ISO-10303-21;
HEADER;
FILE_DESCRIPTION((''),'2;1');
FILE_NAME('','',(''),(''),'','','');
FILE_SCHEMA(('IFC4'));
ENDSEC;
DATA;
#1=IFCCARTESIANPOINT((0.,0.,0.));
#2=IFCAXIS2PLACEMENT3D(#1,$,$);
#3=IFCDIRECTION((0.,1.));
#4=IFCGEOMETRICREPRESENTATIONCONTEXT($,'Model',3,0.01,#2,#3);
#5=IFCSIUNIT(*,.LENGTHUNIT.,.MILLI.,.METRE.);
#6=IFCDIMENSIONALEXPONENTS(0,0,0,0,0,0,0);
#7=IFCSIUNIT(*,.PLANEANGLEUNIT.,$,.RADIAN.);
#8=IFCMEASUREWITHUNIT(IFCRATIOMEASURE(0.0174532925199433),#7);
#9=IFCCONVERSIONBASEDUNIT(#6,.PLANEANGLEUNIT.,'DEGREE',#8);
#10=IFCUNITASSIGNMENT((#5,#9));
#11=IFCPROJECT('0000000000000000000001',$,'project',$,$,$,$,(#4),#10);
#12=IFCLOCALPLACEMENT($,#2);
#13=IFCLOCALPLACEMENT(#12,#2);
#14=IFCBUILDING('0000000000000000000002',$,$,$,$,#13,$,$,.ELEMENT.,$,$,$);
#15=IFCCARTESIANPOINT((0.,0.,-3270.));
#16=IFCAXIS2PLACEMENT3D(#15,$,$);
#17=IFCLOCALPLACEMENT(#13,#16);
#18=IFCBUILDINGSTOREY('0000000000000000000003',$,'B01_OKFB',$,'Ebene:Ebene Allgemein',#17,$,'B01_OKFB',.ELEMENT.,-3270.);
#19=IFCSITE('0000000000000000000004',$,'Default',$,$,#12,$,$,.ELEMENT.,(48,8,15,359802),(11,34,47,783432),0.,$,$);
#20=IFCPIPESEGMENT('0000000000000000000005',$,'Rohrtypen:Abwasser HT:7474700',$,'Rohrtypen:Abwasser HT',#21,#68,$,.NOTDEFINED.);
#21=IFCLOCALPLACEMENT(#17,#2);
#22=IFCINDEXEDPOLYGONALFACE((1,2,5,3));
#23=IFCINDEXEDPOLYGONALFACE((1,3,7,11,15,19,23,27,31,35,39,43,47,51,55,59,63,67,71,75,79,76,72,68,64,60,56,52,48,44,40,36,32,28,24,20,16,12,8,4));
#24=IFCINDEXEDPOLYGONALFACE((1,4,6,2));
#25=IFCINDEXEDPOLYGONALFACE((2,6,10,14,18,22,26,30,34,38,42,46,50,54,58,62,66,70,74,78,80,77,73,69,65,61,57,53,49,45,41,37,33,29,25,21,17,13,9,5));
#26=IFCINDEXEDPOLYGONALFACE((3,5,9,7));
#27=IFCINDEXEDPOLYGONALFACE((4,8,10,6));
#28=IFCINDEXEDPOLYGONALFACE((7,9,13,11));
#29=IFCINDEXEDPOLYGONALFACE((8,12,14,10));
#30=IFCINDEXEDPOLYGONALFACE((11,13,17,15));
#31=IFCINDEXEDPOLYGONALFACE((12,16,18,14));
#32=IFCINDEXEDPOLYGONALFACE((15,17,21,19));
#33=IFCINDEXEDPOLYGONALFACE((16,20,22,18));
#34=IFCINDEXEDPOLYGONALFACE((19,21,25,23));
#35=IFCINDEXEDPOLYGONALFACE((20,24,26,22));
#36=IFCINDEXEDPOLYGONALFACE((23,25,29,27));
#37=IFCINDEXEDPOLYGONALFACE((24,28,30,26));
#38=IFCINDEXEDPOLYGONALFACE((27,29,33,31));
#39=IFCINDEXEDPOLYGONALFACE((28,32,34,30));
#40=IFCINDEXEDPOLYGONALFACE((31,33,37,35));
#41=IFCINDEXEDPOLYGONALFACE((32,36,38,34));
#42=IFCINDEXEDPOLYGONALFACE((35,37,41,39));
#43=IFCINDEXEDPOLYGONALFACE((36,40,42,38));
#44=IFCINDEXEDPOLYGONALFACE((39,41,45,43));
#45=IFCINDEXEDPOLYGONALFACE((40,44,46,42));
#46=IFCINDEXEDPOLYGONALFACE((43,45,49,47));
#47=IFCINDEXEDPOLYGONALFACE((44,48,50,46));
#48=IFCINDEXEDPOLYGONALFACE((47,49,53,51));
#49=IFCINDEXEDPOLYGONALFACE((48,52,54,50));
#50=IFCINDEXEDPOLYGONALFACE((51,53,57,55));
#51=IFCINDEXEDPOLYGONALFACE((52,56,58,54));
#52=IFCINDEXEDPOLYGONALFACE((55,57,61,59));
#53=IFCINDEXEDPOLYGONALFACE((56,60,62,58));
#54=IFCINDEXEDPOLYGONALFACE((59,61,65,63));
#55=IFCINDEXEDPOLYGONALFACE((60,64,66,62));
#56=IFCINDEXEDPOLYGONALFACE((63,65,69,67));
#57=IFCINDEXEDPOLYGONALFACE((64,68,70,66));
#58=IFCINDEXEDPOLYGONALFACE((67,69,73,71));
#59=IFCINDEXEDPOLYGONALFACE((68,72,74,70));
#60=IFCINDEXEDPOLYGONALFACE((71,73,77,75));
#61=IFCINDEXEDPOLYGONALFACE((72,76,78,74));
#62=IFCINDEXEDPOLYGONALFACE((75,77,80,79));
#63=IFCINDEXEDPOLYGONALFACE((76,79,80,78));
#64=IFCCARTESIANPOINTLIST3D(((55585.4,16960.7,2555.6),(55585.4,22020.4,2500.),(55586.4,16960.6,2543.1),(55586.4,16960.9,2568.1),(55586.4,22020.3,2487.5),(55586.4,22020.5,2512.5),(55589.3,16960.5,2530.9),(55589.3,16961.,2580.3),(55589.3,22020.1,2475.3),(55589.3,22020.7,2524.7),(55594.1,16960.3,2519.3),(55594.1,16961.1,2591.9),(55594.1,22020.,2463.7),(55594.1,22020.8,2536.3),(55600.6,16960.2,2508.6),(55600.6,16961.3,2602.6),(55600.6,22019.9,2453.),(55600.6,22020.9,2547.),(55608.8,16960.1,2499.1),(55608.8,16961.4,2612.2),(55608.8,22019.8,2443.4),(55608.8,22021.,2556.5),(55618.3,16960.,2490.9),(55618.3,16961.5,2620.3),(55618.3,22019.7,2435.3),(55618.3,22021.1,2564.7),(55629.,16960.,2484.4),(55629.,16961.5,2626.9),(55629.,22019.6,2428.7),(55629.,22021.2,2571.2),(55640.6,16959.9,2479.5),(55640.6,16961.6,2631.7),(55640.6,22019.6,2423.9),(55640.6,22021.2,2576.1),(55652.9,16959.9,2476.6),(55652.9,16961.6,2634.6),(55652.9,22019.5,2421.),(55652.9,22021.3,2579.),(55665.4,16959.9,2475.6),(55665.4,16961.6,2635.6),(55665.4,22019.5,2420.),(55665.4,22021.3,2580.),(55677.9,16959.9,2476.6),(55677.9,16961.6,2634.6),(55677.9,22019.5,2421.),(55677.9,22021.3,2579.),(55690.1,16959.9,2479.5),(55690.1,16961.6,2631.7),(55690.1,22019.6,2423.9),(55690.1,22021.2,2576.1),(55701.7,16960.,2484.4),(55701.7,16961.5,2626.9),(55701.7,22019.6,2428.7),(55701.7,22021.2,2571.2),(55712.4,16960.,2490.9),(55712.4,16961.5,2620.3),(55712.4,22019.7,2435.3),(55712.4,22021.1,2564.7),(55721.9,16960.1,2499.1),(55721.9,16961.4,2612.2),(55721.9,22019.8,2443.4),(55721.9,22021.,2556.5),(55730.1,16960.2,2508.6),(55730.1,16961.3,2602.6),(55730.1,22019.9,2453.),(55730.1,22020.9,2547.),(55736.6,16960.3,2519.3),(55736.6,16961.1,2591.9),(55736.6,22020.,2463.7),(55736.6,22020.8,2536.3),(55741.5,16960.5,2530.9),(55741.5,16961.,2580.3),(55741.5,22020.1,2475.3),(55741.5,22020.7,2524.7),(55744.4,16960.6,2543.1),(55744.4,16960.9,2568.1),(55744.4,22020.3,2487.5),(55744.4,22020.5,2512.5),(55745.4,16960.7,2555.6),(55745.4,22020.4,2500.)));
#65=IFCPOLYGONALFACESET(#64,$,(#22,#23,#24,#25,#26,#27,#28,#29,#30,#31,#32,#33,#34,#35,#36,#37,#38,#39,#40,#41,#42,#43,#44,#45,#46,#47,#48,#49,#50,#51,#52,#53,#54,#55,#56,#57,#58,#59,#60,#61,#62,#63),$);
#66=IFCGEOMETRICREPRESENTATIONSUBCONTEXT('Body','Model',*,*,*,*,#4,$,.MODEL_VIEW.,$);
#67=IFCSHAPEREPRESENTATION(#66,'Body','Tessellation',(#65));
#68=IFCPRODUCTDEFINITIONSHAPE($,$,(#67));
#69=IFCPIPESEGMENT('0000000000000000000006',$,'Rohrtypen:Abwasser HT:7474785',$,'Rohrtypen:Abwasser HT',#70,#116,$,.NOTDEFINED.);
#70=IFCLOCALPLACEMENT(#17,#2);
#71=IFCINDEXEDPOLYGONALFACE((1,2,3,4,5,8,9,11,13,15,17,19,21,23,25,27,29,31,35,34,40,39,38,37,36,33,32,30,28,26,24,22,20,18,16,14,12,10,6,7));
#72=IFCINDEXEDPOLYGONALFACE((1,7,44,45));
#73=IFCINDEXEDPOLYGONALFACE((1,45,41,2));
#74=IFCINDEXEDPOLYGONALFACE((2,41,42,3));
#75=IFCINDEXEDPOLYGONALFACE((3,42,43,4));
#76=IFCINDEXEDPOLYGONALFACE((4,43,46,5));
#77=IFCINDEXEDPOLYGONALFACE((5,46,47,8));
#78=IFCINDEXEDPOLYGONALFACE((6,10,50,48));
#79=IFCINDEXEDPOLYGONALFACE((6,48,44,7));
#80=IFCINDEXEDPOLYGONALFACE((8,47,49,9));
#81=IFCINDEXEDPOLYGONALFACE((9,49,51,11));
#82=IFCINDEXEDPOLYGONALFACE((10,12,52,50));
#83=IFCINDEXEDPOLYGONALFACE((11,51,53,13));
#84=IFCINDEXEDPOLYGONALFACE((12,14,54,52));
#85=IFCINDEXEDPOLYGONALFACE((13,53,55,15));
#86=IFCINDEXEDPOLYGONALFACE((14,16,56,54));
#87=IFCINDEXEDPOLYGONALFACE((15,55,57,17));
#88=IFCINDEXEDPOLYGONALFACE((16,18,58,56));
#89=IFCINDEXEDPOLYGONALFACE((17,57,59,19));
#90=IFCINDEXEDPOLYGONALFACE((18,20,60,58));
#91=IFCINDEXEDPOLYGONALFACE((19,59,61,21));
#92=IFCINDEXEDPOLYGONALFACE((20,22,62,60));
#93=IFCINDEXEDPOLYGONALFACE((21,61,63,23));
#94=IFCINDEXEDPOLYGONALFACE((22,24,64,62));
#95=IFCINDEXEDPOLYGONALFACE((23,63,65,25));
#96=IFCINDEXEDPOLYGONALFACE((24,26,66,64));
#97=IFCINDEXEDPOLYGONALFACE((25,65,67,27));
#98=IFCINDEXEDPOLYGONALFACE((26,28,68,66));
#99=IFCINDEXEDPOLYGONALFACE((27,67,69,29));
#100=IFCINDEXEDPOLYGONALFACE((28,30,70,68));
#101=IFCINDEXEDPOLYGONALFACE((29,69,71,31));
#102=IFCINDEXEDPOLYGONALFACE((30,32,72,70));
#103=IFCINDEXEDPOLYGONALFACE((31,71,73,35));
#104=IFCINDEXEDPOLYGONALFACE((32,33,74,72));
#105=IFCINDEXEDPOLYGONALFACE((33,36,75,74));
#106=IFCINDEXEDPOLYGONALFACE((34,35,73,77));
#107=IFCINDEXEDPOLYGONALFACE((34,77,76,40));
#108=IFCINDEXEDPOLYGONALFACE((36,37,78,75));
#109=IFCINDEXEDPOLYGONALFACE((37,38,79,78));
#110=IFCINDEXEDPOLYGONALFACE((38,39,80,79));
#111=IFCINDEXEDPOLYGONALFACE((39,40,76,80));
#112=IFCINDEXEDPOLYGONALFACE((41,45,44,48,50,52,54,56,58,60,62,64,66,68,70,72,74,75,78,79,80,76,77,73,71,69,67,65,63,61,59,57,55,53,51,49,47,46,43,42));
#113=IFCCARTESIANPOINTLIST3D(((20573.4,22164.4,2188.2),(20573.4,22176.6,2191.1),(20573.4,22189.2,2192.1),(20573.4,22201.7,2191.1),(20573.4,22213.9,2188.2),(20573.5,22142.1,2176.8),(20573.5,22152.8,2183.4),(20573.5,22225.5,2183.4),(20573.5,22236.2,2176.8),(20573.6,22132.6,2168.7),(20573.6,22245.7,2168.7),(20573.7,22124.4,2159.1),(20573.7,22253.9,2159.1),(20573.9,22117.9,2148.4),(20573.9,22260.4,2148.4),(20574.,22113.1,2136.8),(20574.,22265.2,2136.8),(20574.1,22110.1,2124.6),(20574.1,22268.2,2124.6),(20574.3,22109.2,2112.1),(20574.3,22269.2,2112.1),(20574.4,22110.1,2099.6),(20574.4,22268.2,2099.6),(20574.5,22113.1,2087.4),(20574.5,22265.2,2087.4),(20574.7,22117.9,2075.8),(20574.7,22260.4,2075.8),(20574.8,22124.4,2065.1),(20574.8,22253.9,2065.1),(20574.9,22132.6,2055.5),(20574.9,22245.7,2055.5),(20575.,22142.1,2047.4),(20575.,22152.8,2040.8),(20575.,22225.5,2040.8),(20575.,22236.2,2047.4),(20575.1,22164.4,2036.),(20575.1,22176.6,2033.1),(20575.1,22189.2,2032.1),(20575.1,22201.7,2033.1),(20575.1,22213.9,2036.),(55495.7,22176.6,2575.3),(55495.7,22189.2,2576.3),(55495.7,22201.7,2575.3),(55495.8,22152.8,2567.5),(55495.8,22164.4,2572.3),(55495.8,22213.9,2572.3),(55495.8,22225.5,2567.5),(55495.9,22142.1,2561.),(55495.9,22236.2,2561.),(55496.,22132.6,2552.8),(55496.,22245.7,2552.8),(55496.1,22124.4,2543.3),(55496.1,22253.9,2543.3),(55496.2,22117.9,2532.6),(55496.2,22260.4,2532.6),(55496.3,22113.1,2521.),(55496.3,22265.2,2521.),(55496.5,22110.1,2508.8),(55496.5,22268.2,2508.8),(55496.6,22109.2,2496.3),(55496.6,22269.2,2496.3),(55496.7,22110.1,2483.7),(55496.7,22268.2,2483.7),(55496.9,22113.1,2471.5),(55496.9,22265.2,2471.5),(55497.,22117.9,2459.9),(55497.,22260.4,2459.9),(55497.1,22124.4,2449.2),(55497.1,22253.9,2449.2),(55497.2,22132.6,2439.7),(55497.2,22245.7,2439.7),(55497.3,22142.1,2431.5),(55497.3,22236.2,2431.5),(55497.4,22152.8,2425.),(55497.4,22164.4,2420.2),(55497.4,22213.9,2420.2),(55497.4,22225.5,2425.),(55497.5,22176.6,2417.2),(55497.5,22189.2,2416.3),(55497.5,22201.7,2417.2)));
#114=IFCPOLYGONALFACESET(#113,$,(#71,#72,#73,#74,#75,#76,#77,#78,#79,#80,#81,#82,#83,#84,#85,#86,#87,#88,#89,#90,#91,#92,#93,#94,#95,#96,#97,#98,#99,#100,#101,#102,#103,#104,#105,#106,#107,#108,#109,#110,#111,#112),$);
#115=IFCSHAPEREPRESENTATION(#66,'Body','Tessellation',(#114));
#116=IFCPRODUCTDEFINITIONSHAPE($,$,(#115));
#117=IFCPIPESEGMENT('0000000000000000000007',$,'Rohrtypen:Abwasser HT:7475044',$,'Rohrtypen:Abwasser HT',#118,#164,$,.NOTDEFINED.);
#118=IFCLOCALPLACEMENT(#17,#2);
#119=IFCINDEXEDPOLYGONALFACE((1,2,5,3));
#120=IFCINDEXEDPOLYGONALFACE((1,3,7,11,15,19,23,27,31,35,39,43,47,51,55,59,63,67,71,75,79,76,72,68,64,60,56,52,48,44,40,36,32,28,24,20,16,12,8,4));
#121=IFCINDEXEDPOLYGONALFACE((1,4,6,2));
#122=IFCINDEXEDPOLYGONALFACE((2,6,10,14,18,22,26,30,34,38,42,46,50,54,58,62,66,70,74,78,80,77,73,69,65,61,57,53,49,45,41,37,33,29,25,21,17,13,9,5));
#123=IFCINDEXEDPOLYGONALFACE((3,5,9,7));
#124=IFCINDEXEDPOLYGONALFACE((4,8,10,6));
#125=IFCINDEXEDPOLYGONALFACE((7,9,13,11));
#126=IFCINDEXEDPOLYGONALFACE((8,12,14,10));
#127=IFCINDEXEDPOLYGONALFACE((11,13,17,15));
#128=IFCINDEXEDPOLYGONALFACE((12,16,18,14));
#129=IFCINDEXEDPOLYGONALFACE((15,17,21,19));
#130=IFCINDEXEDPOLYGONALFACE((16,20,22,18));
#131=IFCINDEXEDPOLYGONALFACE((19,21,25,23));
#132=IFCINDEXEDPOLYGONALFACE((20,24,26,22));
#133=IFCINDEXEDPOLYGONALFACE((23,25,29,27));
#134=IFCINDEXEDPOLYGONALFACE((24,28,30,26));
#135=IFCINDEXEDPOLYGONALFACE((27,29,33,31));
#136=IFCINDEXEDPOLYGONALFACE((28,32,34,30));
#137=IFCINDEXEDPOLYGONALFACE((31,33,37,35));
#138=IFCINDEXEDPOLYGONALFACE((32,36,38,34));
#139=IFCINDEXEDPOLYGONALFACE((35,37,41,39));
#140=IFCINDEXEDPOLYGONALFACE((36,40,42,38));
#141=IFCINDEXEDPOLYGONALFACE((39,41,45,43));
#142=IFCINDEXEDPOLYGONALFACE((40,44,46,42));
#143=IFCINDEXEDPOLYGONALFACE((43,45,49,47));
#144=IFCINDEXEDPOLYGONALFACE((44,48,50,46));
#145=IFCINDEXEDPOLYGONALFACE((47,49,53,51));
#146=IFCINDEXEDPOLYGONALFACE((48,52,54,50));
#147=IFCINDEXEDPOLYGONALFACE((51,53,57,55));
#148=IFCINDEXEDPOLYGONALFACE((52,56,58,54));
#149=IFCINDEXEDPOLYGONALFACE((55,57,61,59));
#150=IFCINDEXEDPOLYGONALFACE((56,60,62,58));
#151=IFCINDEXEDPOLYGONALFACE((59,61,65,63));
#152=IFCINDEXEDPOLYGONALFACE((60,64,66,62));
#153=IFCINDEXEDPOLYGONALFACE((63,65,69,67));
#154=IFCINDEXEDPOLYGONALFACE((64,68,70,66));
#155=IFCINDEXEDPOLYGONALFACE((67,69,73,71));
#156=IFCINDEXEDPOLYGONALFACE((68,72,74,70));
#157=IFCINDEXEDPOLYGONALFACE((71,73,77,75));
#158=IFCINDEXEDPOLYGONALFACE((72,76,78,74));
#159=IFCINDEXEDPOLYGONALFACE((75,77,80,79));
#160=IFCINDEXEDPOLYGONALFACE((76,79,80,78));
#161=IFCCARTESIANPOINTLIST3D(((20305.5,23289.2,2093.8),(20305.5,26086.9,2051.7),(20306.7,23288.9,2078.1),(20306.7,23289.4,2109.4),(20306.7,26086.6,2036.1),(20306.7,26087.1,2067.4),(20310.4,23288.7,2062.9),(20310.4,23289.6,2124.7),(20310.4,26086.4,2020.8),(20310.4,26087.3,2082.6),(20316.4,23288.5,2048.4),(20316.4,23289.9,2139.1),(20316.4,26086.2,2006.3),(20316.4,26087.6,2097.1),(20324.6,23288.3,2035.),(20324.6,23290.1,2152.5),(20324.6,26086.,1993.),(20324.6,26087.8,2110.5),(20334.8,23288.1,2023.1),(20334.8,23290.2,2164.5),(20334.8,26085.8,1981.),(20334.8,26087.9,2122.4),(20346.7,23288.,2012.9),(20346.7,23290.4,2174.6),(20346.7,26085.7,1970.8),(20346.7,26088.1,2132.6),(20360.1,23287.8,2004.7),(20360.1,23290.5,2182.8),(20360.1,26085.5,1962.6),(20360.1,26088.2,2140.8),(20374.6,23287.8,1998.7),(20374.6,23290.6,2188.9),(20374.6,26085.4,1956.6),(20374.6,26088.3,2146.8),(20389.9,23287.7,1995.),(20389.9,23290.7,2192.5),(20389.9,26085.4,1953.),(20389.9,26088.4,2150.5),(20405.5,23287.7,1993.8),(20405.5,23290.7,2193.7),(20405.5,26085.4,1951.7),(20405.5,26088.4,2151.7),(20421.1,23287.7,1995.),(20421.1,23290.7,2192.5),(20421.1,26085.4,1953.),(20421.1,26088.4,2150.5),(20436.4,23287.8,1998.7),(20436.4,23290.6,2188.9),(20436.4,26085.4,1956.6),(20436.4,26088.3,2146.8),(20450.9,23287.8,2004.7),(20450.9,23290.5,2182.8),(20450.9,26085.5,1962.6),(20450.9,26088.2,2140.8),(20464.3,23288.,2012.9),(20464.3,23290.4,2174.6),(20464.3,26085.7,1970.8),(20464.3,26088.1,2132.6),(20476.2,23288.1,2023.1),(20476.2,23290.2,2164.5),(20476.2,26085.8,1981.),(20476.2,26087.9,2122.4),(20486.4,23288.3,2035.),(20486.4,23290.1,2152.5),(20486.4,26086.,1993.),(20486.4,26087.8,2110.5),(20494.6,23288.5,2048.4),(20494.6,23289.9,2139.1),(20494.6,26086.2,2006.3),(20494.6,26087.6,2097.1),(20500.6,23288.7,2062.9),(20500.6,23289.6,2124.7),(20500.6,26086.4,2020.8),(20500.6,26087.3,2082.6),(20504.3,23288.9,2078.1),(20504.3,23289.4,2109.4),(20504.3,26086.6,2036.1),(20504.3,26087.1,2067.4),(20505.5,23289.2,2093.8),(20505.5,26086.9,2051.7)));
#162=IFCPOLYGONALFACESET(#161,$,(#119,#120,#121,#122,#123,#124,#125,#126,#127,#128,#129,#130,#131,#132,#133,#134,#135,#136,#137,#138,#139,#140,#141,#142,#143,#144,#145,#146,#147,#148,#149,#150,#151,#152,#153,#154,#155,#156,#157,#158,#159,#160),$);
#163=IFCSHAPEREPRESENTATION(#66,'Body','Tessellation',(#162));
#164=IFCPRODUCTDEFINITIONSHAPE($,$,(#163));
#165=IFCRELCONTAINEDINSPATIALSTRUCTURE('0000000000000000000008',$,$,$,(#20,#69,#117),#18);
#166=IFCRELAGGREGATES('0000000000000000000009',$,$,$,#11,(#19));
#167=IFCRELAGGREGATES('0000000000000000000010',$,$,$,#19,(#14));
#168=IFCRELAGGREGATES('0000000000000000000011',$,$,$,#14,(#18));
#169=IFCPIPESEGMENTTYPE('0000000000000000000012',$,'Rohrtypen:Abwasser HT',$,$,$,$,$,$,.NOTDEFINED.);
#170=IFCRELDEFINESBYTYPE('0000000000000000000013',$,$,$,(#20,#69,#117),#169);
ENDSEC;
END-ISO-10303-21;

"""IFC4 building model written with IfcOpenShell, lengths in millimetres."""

from ifc_helpers import new_model, entity, si_unit, converted_unit, direction, frame, origin, place, context, subcontext, project, spatial, indexed_curve, outline, extrude, type_object, element, save


model = new_model("IFC4")

# Units and contexts
model_context = context("Model", 3, precision=0.01, world=origin(), true_north=direction((0.0, 1.0)))
body_context = subcontext(model_context, "Body", "Model", "MODEL_VIEW")
ifc_project = project(units=[si_unit("LENGTHUNIT", "METRE", prefix="MILLI"), converted_unit("PLANEANGLEUNIT", "DEGREE", entity("IfcRatioMeasure", 0.0174532925199433), si_unit("PLANEANGLEUNIT", "RADIAN"), dimensions=[0, 0, 0, 0, 0, 0, 0])], contexts=[model_context])

# Site, building, storey
site_placement = place(None, origin())
site = spatial("IfcSite", under=ifc_project, at=site_placement, Name="Default", CompositionType="ELEMENT", RefLatitude=(48, 8, 15, 359802), RefLongitude=(11, 34, 47, 783432), RefElevation=0.0)
building_placement = place(site_placement, origin())
building = spatial("IfcBuilding", under=site, at=building_placement, CompositionType="ELEMENT")
storey_placement = place(building_placement, frame((0.0, 0.0, -3270.0)))
storey = spatial("IfcBuildingStorey", under=building, at=storey_placement, Name="B01_OKFB", ObjectType="Ebene:Ebene Allgemein", LongName="B01_OKFB", CompositionType="ELEMENT", Elevation=-3270.0)

# Pipe segments
pipe_segment_type_1 = type_object("IfcPipeSegmentType", Name="Rohrtypen:Abwasser HT", PredefinedType="NOTDEFINED")
pipe_segment_1_placement = place(storey_placement, origin())
element("IfcPipeSegment", 1, at=pipe_segment_1_placement, inside=storey, type_object=pipe_segment_type_1, Name="Rohrtypen:Abwasser HT:7474700", ObjectType="Rohrtypen:Abwasser HT", PredefinedType="NOTDEFINED", context=body_context, shape_type="SweptSolid", body=[
    extrude(outline(indexed_curve([(80.0, 0.0), (79.0, 12.5), (76.1, 24.7), (71.3, 36.3), (64.7, 47.0), (56.6, 56.6), (47.0, 64.7), (36.3, 71.3), (24.7, 76.1), (12.5, 79.0), (0.0, 80.0), (-12.5, 79.0), (-24.7, 76.1), (-36.3, 71.3), (-47.0, 64.7), (-56.6, 56.6), (-64.7, 47.0), (-71.3, 36.3), (-76.1, 24.7), (-79.0, 12.5), (-80.0, 0.0), (-79.0, -12.5), (-76.1, -24.7), (-71.3, -36.3), (-64.7, -47.0), (-56.6, -56.6), (-47.0, -64.7), (-36.3, -71.3), (-24.7, -76.1), (-12.5, -79.0), (0.0, -80.0), (12.5, -79.0), (24.7, -76.1), (36.3, -71.3), (47.0, -64.7), (56.6, -56.6), (64.7, -47.0), (71.3, -36.3), (76.1, -24.7), (79.0, -12.5), (80.0, 0.0)], self_intersect=False)), frame((55665.4, 22020.4, 2500.0), z_axis=(0.0, -0.99994, 0.010999), x_axis=(1.0, 0.0, 0.0)), (0.0, 0.0, 1.0), 5060.0),
])
pipe_segment_2_placement = place(storey_placement, origin())
element("IfcPipeSegment", 2, at=pipe_segment_2_placement, inside=storey, type_object=pipe_segment_type_1, Name="Rohrtypen:Abwasser HT:7474785", ObjectType="Rohrtypen:Abwasser HT", PredefinedType="NOTDEFINED", context=body_context, shape_type="SweptSolid", body=[
    extrude(outline(indexed_curve([(80.0, 0.0), (79.0, 12.5), (76.1, 24.7), (71.3, 36.3), (64.7, 47.0), (56.6, 56.6), (47.0, 64.7), (36.3, 71.3), (24.7, 76.1), (12.5, 79.0), (0.0, 80.0), (-12.5, 79.0), (-24.7, 76.1), (-36.3, 71.3), (-47.0, 64.7), (-56.6, 56.6), (-64.7, 47.0), (-71.3, 36.3), (-76.1, 24.7), (-79.0, 12.5), (-80.0, 0.0), (-79.0, -12.5), (-76.1, -24.7), (-71.3, -36.3), (-64.7, -47.0), (-56.6, -56.6), (-47.0, -64.7), (-36.3, -71.3), (-24.7, -76.1), (-12.5, -79.0), (0.0, -80.0), (12.5, -79.0), (24.7, -76.1), (36.3, -71.3), (47.0, -64.7), (56.6, -56.6), (64.7, -47.0), (71.3, -36.3), (76.1, -24.7), (79.0, -12.5), (80.0, 0.0)], self_intersect=False)), frame((20574.3, 22189.2, 2112.1), z_axis=(0.99994, 0.0, 0.010999), x_axis=(0.0, 1.0, 0.0)), (0.0, 0.0, 1.0), 34924.5),
])
pipe_segment_3_placement = place(storey_placement, origin())
element("IfcPipeSegment", 3, at=pipe_segment_3_placement, inside=storey, type_object=pipe_segment_type_1, Name="Rohrtypen:Abwasser HT:7475044", ObjectType="Rohrtypen:Abwasser HT", PredefinedType="NOTDEFINED", context=body_context, shape_type="SweptSolid", body=[
    extrude(outline(indexed_curve([(100.0, 0.0), (98.8, 15.6), (95.1, 30.9), (89.1, 45.4), (80.9, 58.8), (70.7, 70.7), (58.8, 80.9), (45.4, 89.1), (30.9, 95.1), (15.6, 98.8), (0.0, 100.0), (-15.6, 98.8), (-30.9, 95.1), (-45.4, 89.1), (-58.8, 80.9), (-70.7, 70.7), (-80.9, 58.8), (-89.1, 45.4), (-95.1, 30.9), (-98.8, 15.6), (-100.0, 0.0), (-98.8, -15.6), (-95.1, -30.9), (-89.1, -45.4), (-80.9, -58.8), (-70.7, -70.7), (-58.8, -80.9), (-45.4, -89.1), (-30.9, -95.1), (-15.6, -98.8), (0.0, -100.0), (15.6, -98.8), (30.9, -95.1), (45.4, -89.1), (58.8, -80.9), (70.7, -70.7), (80.9, -58.8), (89.1, -45.4), (95.1, -30.9), (98.8, -15.6), (100.0, 0.0)], self_intersect=False)), frame((20405.5, 23289.2, 2093.8), z_axis=(0.0, 0.999887, -0.015023), x_axis=(1.0, 0.0, 0.0)), (0.0, 0.0, 1.0), 2798.0),
])

save(model, "model.ifc")
